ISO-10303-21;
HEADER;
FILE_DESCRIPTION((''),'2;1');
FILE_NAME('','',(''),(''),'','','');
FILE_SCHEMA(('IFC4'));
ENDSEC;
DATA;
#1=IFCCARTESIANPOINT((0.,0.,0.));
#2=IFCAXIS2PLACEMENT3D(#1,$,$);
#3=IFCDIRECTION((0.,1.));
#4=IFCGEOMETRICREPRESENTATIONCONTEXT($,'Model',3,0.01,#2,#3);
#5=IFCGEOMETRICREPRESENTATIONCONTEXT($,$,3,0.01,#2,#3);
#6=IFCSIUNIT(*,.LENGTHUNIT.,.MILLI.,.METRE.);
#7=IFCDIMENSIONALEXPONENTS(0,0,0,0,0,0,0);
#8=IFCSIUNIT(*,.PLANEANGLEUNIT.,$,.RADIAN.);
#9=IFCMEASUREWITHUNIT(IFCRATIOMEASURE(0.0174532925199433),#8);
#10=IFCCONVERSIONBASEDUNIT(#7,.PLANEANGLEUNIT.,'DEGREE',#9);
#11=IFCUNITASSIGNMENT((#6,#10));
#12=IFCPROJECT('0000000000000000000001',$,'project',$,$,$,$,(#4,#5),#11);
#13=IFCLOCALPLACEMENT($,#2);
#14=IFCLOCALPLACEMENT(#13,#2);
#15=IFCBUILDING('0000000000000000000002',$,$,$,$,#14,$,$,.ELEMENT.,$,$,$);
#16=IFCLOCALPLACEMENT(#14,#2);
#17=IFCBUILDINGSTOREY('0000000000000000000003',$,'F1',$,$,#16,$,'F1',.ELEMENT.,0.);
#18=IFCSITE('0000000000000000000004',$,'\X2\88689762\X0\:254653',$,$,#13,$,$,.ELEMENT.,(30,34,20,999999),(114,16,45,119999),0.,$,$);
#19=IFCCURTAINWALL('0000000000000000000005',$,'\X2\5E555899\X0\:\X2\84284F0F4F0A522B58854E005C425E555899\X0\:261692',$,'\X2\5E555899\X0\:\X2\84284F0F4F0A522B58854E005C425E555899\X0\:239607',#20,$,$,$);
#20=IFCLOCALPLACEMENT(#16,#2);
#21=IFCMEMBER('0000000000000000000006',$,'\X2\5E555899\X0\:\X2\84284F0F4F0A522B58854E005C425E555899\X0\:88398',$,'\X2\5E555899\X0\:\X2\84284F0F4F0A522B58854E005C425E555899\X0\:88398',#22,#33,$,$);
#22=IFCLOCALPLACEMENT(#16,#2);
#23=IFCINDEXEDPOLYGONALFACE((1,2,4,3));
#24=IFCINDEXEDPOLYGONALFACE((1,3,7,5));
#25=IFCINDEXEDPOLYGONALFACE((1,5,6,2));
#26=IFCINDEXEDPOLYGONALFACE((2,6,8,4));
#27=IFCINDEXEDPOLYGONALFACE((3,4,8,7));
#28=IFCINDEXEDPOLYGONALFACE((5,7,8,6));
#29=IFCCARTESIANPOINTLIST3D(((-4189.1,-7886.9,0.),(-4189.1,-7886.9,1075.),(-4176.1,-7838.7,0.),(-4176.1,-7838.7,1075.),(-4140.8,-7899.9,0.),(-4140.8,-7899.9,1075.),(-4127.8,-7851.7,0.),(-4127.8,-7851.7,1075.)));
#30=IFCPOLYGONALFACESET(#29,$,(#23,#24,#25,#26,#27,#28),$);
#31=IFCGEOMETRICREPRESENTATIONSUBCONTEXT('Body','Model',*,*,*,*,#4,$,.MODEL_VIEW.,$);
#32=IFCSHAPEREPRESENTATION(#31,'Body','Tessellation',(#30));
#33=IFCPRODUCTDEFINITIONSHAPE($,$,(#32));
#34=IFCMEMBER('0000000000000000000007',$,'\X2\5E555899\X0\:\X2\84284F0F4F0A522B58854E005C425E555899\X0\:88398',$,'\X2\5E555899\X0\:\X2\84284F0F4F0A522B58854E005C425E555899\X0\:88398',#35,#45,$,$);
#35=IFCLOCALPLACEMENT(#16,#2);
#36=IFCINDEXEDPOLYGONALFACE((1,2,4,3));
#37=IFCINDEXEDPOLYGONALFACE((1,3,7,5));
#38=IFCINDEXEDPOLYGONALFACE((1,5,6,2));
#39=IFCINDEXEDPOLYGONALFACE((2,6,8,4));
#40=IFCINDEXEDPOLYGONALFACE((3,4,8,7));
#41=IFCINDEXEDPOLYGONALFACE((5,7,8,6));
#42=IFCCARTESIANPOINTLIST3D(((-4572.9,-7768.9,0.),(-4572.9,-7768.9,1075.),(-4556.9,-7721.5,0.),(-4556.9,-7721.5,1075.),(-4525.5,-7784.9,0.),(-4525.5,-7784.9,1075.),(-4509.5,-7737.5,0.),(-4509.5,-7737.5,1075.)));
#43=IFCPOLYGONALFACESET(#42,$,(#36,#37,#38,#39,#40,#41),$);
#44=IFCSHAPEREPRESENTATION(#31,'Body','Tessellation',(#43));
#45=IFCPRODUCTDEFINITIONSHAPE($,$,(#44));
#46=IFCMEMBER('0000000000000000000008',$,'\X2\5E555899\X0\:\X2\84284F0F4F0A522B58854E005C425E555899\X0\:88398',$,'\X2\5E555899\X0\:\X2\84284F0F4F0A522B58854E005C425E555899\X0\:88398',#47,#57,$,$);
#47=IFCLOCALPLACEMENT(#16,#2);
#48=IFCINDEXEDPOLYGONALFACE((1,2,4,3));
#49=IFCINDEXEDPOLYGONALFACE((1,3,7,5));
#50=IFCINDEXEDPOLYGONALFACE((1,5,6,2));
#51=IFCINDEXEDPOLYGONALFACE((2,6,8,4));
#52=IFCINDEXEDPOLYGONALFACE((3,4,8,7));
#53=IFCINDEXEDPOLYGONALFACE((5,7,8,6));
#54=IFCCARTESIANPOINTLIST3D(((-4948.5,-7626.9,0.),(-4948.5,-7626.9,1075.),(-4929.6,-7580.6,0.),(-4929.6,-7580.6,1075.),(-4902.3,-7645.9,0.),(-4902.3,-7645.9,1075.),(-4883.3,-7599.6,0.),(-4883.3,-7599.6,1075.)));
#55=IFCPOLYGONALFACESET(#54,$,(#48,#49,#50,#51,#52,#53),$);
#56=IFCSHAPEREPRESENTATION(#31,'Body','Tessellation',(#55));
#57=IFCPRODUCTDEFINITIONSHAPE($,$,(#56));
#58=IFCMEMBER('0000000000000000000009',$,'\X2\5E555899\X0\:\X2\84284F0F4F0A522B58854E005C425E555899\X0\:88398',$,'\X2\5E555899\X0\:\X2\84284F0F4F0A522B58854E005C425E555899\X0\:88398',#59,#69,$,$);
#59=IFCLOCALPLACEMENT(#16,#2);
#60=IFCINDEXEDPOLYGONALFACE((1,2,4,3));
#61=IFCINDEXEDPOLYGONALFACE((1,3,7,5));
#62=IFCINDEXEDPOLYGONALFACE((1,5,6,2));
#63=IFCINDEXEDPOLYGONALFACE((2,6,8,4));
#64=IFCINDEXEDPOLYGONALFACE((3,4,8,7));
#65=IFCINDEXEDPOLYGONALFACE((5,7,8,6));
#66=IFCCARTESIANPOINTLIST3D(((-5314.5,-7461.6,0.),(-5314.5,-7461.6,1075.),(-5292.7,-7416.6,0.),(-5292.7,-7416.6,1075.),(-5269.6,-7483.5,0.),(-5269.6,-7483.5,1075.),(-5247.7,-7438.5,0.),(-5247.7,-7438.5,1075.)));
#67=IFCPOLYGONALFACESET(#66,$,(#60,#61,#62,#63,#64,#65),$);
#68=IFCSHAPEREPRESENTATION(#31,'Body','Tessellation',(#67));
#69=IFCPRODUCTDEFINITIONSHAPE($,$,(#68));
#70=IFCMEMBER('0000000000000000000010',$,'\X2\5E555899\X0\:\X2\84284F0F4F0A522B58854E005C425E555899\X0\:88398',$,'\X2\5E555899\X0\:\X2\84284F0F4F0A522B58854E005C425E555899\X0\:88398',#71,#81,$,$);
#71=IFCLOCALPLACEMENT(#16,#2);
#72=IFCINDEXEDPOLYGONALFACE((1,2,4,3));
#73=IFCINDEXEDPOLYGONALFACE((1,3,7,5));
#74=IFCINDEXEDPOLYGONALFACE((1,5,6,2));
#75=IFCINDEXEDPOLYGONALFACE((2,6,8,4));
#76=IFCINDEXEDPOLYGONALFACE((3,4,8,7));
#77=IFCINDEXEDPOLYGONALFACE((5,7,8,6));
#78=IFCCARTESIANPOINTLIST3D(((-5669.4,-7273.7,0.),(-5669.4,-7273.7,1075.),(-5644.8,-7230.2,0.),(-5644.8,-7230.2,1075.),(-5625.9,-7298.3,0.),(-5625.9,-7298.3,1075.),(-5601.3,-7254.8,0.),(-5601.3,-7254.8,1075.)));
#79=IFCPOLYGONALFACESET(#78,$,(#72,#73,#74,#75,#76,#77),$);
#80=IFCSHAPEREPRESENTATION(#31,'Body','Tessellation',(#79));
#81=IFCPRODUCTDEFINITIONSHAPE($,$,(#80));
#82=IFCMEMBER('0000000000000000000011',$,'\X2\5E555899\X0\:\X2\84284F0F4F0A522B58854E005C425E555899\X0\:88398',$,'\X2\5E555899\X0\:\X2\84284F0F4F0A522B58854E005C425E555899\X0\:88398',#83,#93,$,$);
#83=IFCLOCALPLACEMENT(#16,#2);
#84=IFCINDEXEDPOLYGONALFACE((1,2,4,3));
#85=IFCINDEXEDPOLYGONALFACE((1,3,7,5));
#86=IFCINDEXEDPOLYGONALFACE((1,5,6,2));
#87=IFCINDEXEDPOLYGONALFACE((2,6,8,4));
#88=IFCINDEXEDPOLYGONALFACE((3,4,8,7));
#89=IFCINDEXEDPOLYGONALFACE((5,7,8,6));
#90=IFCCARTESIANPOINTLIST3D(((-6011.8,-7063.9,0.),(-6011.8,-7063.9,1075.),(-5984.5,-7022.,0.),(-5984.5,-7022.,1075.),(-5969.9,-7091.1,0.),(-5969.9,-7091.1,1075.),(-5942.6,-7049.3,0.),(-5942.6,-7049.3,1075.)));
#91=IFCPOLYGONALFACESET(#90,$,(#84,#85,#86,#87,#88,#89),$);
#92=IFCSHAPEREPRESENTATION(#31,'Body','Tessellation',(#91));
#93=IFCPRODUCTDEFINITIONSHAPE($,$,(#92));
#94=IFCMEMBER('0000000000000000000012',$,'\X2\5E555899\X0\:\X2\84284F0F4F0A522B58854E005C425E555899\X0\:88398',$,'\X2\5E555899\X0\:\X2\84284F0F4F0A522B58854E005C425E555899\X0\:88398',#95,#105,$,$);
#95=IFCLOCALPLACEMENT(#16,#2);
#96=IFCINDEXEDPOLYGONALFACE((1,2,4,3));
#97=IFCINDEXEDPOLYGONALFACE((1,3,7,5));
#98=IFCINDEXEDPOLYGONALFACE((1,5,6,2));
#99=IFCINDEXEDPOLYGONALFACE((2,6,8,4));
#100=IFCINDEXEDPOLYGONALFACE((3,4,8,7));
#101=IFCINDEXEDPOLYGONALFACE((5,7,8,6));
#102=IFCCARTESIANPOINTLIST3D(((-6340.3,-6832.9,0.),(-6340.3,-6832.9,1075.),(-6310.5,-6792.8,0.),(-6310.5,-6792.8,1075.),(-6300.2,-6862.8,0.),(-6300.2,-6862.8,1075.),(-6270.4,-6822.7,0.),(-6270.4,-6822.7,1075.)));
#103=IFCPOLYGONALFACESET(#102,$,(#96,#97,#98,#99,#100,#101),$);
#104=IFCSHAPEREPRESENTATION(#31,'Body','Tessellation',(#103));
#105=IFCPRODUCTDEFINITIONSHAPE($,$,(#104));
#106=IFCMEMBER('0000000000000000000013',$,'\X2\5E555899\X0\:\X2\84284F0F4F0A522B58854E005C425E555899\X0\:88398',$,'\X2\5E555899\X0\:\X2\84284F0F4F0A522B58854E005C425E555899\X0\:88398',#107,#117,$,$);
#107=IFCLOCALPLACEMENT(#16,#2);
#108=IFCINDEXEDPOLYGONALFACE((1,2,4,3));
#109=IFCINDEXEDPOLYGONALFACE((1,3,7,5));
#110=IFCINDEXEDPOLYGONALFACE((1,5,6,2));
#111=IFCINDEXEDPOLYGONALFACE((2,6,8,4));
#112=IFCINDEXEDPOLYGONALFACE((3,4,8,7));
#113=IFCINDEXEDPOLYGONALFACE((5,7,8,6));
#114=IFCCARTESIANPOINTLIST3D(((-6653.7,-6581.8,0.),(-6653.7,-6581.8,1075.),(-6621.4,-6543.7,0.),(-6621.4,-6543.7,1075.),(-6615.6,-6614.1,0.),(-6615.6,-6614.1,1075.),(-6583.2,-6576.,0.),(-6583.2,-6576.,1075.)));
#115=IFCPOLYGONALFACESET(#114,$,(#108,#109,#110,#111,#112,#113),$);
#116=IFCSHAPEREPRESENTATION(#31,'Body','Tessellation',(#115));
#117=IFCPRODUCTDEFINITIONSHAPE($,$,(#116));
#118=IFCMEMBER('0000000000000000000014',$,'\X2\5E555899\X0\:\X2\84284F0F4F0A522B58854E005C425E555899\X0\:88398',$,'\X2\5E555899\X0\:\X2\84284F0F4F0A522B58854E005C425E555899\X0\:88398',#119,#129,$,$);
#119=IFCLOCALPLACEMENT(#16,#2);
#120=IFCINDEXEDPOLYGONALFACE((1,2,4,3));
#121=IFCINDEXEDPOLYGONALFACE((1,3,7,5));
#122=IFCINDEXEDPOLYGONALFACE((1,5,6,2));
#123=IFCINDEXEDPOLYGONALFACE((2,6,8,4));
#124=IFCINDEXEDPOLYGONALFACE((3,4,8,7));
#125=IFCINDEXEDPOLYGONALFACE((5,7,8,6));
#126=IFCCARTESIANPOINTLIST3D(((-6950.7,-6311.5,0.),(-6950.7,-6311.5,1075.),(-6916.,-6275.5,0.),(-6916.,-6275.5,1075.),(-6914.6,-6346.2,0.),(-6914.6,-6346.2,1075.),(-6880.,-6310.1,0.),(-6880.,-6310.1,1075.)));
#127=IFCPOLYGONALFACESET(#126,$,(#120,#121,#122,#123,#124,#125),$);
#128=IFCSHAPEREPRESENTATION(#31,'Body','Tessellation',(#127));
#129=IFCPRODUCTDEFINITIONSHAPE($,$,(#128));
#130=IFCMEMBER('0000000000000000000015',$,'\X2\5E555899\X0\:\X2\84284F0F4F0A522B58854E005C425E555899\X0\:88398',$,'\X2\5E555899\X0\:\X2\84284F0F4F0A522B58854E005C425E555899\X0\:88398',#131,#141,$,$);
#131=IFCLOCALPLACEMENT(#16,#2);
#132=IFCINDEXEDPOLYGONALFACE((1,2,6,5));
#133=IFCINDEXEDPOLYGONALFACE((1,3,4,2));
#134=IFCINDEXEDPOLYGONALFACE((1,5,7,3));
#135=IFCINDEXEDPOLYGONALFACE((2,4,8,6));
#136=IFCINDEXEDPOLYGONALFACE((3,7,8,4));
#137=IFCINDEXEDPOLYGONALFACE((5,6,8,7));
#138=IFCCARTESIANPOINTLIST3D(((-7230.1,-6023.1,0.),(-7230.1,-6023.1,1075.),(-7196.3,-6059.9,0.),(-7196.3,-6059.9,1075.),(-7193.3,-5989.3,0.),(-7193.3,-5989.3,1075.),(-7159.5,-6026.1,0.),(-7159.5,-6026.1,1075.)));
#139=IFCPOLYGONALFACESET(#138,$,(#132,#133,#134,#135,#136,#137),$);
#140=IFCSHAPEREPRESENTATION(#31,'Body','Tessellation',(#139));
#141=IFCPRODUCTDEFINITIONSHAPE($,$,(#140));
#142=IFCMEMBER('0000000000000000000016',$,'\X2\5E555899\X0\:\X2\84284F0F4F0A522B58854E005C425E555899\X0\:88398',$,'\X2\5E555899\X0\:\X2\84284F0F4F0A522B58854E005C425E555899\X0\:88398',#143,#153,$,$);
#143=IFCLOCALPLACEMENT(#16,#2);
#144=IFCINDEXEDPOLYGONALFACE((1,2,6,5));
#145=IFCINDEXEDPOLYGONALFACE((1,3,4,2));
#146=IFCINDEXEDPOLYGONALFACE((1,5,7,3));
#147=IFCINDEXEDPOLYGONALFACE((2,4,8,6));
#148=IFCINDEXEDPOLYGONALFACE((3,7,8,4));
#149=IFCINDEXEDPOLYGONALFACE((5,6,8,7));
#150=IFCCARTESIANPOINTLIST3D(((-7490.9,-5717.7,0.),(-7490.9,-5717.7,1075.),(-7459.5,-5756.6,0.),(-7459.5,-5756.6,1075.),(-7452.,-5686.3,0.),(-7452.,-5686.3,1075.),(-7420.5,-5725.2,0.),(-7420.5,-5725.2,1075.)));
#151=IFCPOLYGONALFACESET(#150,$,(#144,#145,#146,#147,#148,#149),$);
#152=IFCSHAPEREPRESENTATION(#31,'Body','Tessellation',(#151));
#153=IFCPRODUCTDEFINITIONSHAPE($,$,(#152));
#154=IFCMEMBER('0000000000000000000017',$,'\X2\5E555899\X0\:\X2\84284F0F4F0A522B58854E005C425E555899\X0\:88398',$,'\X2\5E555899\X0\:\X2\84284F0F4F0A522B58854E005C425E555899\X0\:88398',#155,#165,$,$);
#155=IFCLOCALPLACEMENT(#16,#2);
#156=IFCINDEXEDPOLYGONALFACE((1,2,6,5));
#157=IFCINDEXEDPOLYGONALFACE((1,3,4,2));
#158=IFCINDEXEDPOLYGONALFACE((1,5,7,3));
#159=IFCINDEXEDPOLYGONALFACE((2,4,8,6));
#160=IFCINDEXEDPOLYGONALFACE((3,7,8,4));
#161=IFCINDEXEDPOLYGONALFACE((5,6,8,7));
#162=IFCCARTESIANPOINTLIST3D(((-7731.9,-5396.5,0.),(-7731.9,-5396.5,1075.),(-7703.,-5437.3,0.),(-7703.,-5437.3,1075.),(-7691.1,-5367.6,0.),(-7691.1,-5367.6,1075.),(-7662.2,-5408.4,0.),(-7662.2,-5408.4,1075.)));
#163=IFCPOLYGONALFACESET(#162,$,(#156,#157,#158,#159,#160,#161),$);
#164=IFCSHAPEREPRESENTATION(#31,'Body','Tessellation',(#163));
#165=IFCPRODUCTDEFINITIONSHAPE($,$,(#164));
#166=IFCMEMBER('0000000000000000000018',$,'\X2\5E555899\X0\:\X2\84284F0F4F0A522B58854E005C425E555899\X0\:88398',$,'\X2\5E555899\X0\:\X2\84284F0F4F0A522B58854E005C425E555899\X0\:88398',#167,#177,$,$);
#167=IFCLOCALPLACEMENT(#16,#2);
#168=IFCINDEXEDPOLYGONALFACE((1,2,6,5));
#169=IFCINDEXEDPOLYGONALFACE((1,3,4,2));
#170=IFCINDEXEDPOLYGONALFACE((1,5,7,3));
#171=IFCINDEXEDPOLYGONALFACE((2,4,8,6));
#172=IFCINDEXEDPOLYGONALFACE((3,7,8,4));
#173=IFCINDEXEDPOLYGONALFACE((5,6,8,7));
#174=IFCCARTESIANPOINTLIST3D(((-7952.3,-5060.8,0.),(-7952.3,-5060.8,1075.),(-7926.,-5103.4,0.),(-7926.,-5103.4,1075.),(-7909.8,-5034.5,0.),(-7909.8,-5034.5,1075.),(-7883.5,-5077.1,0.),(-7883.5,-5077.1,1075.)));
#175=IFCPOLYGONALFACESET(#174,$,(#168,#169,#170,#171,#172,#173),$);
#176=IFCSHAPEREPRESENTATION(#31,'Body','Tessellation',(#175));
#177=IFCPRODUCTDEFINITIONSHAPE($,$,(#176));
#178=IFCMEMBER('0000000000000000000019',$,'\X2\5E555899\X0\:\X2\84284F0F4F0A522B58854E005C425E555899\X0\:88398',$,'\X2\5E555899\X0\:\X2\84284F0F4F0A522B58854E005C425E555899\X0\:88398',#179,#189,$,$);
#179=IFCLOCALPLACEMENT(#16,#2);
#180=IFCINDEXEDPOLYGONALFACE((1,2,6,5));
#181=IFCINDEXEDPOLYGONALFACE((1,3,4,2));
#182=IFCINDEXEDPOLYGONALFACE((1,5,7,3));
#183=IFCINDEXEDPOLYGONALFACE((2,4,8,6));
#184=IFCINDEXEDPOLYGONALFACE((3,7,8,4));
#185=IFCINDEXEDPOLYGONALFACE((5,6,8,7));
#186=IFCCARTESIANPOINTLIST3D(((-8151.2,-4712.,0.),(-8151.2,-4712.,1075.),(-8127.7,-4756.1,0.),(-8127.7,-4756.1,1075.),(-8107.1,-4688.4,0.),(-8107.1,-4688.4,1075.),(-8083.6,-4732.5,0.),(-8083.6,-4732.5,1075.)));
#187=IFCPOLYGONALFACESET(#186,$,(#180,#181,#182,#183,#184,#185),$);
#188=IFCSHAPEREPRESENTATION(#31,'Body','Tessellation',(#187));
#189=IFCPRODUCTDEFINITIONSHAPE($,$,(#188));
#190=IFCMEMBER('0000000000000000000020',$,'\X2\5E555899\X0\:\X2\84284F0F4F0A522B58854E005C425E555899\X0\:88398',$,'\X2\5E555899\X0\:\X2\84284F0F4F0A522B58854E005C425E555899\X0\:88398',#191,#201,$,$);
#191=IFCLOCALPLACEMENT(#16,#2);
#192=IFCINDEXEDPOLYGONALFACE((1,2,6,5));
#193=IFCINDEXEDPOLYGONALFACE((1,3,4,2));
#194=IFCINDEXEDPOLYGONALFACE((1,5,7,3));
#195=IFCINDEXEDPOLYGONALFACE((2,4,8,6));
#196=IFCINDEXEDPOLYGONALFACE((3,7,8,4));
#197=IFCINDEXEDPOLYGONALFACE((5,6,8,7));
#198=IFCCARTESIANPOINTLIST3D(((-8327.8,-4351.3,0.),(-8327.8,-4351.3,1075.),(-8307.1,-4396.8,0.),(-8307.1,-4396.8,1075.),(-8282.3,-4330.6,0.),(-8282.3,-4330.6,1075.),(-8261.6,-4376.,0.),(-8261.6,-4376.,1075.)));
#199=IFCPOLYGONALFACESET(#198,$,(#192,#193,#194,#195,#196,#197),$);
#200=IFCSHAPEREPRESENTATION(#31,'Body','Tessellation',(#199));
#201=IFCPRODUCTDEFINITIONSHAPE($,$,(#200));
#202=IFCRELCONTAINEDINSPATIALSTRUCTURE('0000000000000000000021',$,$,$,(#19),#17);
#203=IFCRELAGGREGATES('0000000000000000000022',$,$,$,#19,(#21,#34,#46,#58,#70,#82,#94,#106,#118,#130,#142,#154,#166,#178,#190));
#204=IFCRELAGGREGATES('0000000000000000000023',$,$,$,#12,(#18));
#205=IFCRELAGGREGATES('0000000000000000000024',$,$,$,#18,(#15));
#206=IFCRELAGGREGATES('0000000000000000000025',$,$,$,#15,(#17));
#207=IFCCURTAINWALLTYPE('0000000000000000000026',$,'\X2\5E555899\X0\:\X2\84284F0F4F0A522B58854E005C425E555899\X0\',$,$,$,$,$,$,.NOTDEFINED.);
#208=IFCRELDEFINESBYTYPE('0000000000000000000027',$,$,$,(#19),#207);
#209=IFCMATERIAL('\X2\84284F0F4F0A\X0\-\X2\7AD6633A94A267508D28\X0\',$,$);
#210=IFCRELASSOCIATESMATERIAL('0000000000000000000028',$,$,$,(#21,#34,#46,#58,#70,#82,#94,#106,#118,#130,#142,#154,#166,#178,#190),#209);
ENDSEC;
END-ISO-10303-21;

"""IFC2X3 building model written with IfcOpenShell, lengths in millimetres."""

from ifc_helpers import new_model, entity, si_unit, converted_unit, direction, frame, frame_2d, origin, origin_2d_with_axis, place, context, subcontext, project, spatial, rectangle, extrude, material, type_object, element, aggregate, save


model = new_model("IFC2X3")

# Units and contexts
model_context = context("Model", 3, precision=0.01, world=origin(), true_north=direction((0.0, 1.0)))
context_of_model = context(None, 3, precision=0.01, world=origin(), true_north=direction((0.0, 1.0)))
body_context = subcontext(model_context, "Body", "Model", "MODEL_VIEW")
ifc_project = project(units=[si_unit("LENGTHUNIT", "METRE", prefix="MILLI"), converted_unit("PLANEANGLEUNIT", "DEGREE", entity("IfcRatioMeasure", 0.0174532925199433), si_unit("PLANEANGLEUNIT", "RADIAN"), dimensions=[0, 0, 0, 0, 0, 0, 0])], contexts=[model_context, context_of_model])

# Site, building, storey
site_placement = place(None, origin())
site = spatial("IfcSite", under=ifc_project, at=site_placement, Name="表面:254653", CompositionType="ELEMENT", RefLatitude=(30, 34, 20, 999999), RefLongitude=(114, 16, 45, 119999), RefElevation=0.0)
building_placement = place(site_placement, origin())
building = spatial("IfcBuilding", under=site, at=building_placement, CompositionType="ELEMENT")
storey_placement = place(building_placement, origin())
storey = spatial("IfcBuildingStorey", under=building, at=storey_placement, Name="F1", LongName="F1", CompositionType="ELEMENT", Elevation=0.0)

# Curtain wall, members
curtain_wall_type = type_object("IfcCurtainWallType", Name="幕墙:萨伏伊别墅一层幕墙", PredefinedType="NOTDEFINED")
curtain_wall_placement = place(storey_placement, origin())
curtain_wall = element("IfcCurtainWall", 1, at=curtain_wall_placement, inside=storey, type_object=curtain_wall_type, Name="幕墙:萨伏伊别墅一层幕墙:261692", ObjectType="幕墙:萨伏伊别墅一层幕墙:239607")
ifc_material_1 = material(Name="萨伏伊-竖挺钢材质")
member_1_placement = place(curtain_wall_placement, origin())
member_1 = element("IfcMember", 2, at=member_1_placement, material=ifc_material_1, Name="幕墙:萨伏伊别墅一层幕墙:88398", ObjectType="幕墙:萨伏伊别墅一层幕墙:88398", context=body_context, shape_type="SweptSolid", body=[
    extrude(rectangle(XDim=50.0, YDim=50.0, at=frame_2d((0.0, 0.0), x_axis=(1.0, 0.0))), frame((-4158.4, -7869.3, 0.0), z_axis=(0.0, 0.0, 1.0), x_axis=(0.2601, 0.965582, 0.0)), (0.0, 0.0, 1.0), 1075.0),
])
member_2_placement = place(curtain_wall_placement, origin())
member_2 = element("IfcMember", 3, at=member_2_placement, material=ifc_material_1, Name="幕墙:萨伏伊别墅一层幕墙:88398", ObjectType="幕墙:萨伏伊别墅一层幕墙:88398", context=body_context, shape_type="SweptSolid", body=[
    extrude(rectangle(XDim=50.0, YDim=50.0, at=origin_2d_with_axis()), frame((-4541.2, -7753.2, 0.0), z_axis=(0.0, 0.0, 1.0), x_axis=(0.320231, 0.947339, 0.0)), (0.0, 0.0, 1.0), 1075.0),
])
member_3_placement = place(curtain_wall_placement, origin())
member_3 = element("IfcMember", 4, at=member_3_placement, material=ifc_material_1, Name="幕墙:萨伏伊别墅一层幕墙:88398", ObjectType="幕墙:萨伏伊别墅一层幕墙:88398", context=body_context, shape_type="SweptSolid", body=[
    extrude(rectangle(XDim=50.0, YDim=50.0, at=frame_2d((0.0, 0.0), x_axis=(1.0, 0.0))), frame((-4915.9, -7613.2, 0.0), z_axis=(0.0, 0.0, 1.0), x_axis=(0.379099, 0.925356, 0.0)), (0.0, 0.0, 1.0), 1075.0),
])
member_4_placement = place(curtain_wall_placement, origin())
member_4 = element("IfcMember", 5, at=member_4_placement, material=ifc_material_1, Name="幕墙:萨伏伊别墅一层幕墙:88398", ObjectType="幕墙:萨伏伊别墅一层幕墙:88398", context=body_context, shape_type="SweptSolid", body=[
    extrude(rectangle(XDim=50.0, YDim=50.0, at=frame_2d((0.0, 0.0), x_axis=(1.0, 0.0))), frame((-5281.1, -7450.1, 0.0), z_axis=(0.0, 0.0, 1.0), x_axis=(0.436469, 0.899719, 0.0)), (0.0, 0.0, 1.0), 1075.0),
])
member_5_placement = place(curtain_wall_placement, origin())
member_5 = element("IfcMember", 6, at=member_5_placement, material=ifc_material_1, Name="幕墙:萨伏伊别墅一层幕墙:88398", ObjectType="幕墙:萨伏伊别墅一层幕墙:88398", context=body_context, shape_type="SweptSolid", body=[
    extrude(rectangle(XDim=50.0, YDim=50.0, at=frame_2d((0.0, 0.0), x_axis=(1.0, 0.0))), frame((-5635.4, -7264.2, 0.0), z_axis=(0.0, 0.0, 1.0), x_axis=(0.492116, 0.870529, 0.0)), (0.0, 0.0, 1.0), 1075.0),
])
member_6_placement = place(curtain_wall_placement, origin())
member_6 = element("IfcMember", 7, at=member_6_placement, material=ifc_material_1, Name="幕墙:萨伏伊别墅一层幕墙:88398", ObjectType="幕墙:萨伏伊别墅一层幕墙:88398", context=body_context, shape_type="SweptSolid", body=[
    extrude(rectangle(XDim=50.0, YDim=50.0, at=frame_2d((0.0, 0.0), x_axis=(1.0, 0.0))), frame((-5977.2, -7056.6, 0.0), z_axis=(0.0, 0.0, 1.0), x_axis=(0.54582, 0.837902, 0.0)), (0.0, 0.0, 1.0), 1075.0),
])
member_7_placement = place(curtain_wall_placement, origin())
member_7 = element("IfcMember", 8, at=member_7_placement, material=ifc_material_1, Name="幕墙:萨伏伊别墅一层幕墙:88398", ObjectType="幕墙:萨伏伊别墅一层幕墙:88398", context=body_context, shape_type="SweptSolid", body=[
    extrude(rectangle(XDim=50.0, YDim=50.0, at=frame_2d((0.0, 0.0), x_axis=(1.0, 0.0))), frame((-6305.3, -6827.8, 0.0), z_axis=(0.0, 0.0, 1.0), x_axis=(0.597369, 0.801967, 0.0)), (0.0, 0.0, 1.0), 1075.0),
])
member_8_placement = place(curtain_wall_placement, origin())
member_8 = element("IfcMember", 9, at=member_8_placement, material=ifc_material_1, Name="幕墙:萨伏伊别墅一层幕墙:88398", ObjectType="幕墙:萨伏伊别墅一层幕墙:88398", context=body_context, shape_type="SweptSolid", body=[
    extrude(rectangle(XDim=50.0, YDim=50.0, at=frame_2d((0.0, 0.0), x_axis=(1.0, 0.0))), frame((-6618.5, -6578.9, 0.0), z_axis=(0.0, 0.0, 1.0), x_axis=(0.646558, 0.762864, 0.0)), (0.0, 0.0, 1.0), 1075.0),
])
member_9_placement = place(curtain_wall_placement, origin())
member_9 = element("IfcMember", 10, at=member_9_placement, material=ifc_material_1, Name="幕墙:萨伏伊别墅一层幕墙:88398", ObjectType="幕墙:萨伏伊别墅一层幕墙:88398", context=body_context, shape_type="SweptSolid", body=[
    extrude(rectangle(XDim=50.0, YDim=50.0, at=origin_2d_with_axis()), frame((-6915.3, -6310.8, 0.0), z_axis=(0.0, 0.0, 1.0), x_axis=(0.693195, 0.72075, 0.0)), (0.0, 0.0, 1.0), 1075.0),
])
member_10_placement = place(curtain_wall_placement, origin())
member_10 = element("IfcMember", 11, at=member_10_placement, material=ifc_material_1, Name="幕墙:萨伏伊别墅一层幕墙:88398", ObjectType="幕墙:萨伏伊别墅一层幕墙:88398", context=body_context, shape_type="SweptSolid", body=[
    extrude(rectangle(XDim=50.0, YDim=50.0, at=frame_2d((0.0, 0.0), x_axis=(1.0, 0.0))), frame((-7194.8, -6024.6, 0.0), z_axis=(0.0, 0.0, 1.0), x_axis=(0.737095, 0.675789, 0.0)), (0.0, 0.0, 1.0), 1075.0),
])
member_11_placement = place(curtain_wall_placement, origin())
member_11 = element("IfcMember", 12, at=member_11_placement, material=ifc_material_1, Name="幕墙:萨伏伊别墅一层幕墙:88398", ObjectType="幕墙:萨伏伊别墅一层幕墙:88398", context=body_context, shape_type="SweptSolid", body=[
    extrude(rectangle(XDim=50.0, YDim=50.0, at=origin_2d_with_axis()), frame((-7455.7, -5721.4, 0.0), z_axis=(0.0, 0.0, 1.0), x_axis=(0.778084, 0.62816, 0.0)), (0.0, 0.0, 1.0), 1075.0),
])
member_12_placement = place(curtain_wall_placement, origin())
member_12 = element("IfcMember", 13, at=member_12_placement, material=ifc_material_1, Name="幕墙:萨伏伊别墅一层幕墙:88398", ObjectType="幕墙:萨伏伊别墅一层幕墙:88398", context=body_context, shape_type="SweptSolid", body=[
    extrude(rectangle(XDim=50.0, YDim=50.0, at=frame_2d((0.0, 0.0), x_axis=(1.0, 0.0))), frame((-7697.1, -5402.5, 0.0), z_axis=(0.0, 0.0, 1.0), x_axis=(0.816001, 0.578051, 0.0)), (0.0, 0.0, 1.0), 1075.0),
])
member_13_placement = place(curtain_wall_placement, origin())
member_13 = element("IfcMember", 14, at=member_13_placement, material=ifc_material_1, Name="幕墙:萨伏伊别墅一层幕墙:88398", ObjectType="幕墙:萨伏伊别墅一层幕墙:88398", context=body_context, shape_type="SweptSolid", body=[
    extrude(rectangle(XDim=50.0, YDim=50.0, at=frame_2d((0.0, 0.0), x_axis=(1.0, 0.0))), frame((-7917.9, -5068.9, 0.0), z_axis=(0.0, 0.0, 1.0), x_axis=(-0.525659, 0.850695, 0.0)), (0.0, 0.0, 1.0), 1075.0),
])
member_14_placement = place(curtain_wall_placement, origin())
member_14 = element("IfcMember", 15, at=member_14_placement, material=ifc_material_1, Name="幕墙:萨伏伊别墅一层幕墙:88398", ObjectType="幕墙:萨伏伊别墅一层幕墙:88398", context=body_context, shape_type="SweptSolid", body=[
    extrude(rectangle(XDim=50.0, YDim=50.0, at=frame_2d((0.0, 0.0), x_axis=(1.0, 0.0))), frame((-8117.4, -4722.2, 0.0), z_axis=(0.0, 0.0, 1.0), x_axis=(-0.471192, 0.882031, 0.0)), (0.0, 0.0, 1.0), 1075.0),
])
member_15_placement = place(curtain_wall_placement, origin())
member_15 = element("IfcMember", 16, at=member_15_placement, material=ifc_material_1, Name="幕墙:萨伏伊别墅一层幕墙:88398", ObjectType="幕墙:萨伏伊别墅一层幕墙:88398", context=body_context, shape_type="SweptSolid", body=[
    extrude(rectangle(XDim=50.0, YDim=50.0, at=frame_2d((0.0, 0.0), x_axis=(1.0, 0.0))), frame((-8294.7, -4363.7, 0.0), z_axis=(0.0, 0.0, 1.0), x_axis=(-0.414863, 0.909884, 0.0)), (0.0, 0.0, 1.0), 1075.0),
])
aggregate(curtain_wall, [member_1, member_2, member_3, member_4, member_5, member_6, member_7, member_8, member_9, member_10, member_11, member_12, member_13, member_14, member_15])

save(model, "model.ifc")
